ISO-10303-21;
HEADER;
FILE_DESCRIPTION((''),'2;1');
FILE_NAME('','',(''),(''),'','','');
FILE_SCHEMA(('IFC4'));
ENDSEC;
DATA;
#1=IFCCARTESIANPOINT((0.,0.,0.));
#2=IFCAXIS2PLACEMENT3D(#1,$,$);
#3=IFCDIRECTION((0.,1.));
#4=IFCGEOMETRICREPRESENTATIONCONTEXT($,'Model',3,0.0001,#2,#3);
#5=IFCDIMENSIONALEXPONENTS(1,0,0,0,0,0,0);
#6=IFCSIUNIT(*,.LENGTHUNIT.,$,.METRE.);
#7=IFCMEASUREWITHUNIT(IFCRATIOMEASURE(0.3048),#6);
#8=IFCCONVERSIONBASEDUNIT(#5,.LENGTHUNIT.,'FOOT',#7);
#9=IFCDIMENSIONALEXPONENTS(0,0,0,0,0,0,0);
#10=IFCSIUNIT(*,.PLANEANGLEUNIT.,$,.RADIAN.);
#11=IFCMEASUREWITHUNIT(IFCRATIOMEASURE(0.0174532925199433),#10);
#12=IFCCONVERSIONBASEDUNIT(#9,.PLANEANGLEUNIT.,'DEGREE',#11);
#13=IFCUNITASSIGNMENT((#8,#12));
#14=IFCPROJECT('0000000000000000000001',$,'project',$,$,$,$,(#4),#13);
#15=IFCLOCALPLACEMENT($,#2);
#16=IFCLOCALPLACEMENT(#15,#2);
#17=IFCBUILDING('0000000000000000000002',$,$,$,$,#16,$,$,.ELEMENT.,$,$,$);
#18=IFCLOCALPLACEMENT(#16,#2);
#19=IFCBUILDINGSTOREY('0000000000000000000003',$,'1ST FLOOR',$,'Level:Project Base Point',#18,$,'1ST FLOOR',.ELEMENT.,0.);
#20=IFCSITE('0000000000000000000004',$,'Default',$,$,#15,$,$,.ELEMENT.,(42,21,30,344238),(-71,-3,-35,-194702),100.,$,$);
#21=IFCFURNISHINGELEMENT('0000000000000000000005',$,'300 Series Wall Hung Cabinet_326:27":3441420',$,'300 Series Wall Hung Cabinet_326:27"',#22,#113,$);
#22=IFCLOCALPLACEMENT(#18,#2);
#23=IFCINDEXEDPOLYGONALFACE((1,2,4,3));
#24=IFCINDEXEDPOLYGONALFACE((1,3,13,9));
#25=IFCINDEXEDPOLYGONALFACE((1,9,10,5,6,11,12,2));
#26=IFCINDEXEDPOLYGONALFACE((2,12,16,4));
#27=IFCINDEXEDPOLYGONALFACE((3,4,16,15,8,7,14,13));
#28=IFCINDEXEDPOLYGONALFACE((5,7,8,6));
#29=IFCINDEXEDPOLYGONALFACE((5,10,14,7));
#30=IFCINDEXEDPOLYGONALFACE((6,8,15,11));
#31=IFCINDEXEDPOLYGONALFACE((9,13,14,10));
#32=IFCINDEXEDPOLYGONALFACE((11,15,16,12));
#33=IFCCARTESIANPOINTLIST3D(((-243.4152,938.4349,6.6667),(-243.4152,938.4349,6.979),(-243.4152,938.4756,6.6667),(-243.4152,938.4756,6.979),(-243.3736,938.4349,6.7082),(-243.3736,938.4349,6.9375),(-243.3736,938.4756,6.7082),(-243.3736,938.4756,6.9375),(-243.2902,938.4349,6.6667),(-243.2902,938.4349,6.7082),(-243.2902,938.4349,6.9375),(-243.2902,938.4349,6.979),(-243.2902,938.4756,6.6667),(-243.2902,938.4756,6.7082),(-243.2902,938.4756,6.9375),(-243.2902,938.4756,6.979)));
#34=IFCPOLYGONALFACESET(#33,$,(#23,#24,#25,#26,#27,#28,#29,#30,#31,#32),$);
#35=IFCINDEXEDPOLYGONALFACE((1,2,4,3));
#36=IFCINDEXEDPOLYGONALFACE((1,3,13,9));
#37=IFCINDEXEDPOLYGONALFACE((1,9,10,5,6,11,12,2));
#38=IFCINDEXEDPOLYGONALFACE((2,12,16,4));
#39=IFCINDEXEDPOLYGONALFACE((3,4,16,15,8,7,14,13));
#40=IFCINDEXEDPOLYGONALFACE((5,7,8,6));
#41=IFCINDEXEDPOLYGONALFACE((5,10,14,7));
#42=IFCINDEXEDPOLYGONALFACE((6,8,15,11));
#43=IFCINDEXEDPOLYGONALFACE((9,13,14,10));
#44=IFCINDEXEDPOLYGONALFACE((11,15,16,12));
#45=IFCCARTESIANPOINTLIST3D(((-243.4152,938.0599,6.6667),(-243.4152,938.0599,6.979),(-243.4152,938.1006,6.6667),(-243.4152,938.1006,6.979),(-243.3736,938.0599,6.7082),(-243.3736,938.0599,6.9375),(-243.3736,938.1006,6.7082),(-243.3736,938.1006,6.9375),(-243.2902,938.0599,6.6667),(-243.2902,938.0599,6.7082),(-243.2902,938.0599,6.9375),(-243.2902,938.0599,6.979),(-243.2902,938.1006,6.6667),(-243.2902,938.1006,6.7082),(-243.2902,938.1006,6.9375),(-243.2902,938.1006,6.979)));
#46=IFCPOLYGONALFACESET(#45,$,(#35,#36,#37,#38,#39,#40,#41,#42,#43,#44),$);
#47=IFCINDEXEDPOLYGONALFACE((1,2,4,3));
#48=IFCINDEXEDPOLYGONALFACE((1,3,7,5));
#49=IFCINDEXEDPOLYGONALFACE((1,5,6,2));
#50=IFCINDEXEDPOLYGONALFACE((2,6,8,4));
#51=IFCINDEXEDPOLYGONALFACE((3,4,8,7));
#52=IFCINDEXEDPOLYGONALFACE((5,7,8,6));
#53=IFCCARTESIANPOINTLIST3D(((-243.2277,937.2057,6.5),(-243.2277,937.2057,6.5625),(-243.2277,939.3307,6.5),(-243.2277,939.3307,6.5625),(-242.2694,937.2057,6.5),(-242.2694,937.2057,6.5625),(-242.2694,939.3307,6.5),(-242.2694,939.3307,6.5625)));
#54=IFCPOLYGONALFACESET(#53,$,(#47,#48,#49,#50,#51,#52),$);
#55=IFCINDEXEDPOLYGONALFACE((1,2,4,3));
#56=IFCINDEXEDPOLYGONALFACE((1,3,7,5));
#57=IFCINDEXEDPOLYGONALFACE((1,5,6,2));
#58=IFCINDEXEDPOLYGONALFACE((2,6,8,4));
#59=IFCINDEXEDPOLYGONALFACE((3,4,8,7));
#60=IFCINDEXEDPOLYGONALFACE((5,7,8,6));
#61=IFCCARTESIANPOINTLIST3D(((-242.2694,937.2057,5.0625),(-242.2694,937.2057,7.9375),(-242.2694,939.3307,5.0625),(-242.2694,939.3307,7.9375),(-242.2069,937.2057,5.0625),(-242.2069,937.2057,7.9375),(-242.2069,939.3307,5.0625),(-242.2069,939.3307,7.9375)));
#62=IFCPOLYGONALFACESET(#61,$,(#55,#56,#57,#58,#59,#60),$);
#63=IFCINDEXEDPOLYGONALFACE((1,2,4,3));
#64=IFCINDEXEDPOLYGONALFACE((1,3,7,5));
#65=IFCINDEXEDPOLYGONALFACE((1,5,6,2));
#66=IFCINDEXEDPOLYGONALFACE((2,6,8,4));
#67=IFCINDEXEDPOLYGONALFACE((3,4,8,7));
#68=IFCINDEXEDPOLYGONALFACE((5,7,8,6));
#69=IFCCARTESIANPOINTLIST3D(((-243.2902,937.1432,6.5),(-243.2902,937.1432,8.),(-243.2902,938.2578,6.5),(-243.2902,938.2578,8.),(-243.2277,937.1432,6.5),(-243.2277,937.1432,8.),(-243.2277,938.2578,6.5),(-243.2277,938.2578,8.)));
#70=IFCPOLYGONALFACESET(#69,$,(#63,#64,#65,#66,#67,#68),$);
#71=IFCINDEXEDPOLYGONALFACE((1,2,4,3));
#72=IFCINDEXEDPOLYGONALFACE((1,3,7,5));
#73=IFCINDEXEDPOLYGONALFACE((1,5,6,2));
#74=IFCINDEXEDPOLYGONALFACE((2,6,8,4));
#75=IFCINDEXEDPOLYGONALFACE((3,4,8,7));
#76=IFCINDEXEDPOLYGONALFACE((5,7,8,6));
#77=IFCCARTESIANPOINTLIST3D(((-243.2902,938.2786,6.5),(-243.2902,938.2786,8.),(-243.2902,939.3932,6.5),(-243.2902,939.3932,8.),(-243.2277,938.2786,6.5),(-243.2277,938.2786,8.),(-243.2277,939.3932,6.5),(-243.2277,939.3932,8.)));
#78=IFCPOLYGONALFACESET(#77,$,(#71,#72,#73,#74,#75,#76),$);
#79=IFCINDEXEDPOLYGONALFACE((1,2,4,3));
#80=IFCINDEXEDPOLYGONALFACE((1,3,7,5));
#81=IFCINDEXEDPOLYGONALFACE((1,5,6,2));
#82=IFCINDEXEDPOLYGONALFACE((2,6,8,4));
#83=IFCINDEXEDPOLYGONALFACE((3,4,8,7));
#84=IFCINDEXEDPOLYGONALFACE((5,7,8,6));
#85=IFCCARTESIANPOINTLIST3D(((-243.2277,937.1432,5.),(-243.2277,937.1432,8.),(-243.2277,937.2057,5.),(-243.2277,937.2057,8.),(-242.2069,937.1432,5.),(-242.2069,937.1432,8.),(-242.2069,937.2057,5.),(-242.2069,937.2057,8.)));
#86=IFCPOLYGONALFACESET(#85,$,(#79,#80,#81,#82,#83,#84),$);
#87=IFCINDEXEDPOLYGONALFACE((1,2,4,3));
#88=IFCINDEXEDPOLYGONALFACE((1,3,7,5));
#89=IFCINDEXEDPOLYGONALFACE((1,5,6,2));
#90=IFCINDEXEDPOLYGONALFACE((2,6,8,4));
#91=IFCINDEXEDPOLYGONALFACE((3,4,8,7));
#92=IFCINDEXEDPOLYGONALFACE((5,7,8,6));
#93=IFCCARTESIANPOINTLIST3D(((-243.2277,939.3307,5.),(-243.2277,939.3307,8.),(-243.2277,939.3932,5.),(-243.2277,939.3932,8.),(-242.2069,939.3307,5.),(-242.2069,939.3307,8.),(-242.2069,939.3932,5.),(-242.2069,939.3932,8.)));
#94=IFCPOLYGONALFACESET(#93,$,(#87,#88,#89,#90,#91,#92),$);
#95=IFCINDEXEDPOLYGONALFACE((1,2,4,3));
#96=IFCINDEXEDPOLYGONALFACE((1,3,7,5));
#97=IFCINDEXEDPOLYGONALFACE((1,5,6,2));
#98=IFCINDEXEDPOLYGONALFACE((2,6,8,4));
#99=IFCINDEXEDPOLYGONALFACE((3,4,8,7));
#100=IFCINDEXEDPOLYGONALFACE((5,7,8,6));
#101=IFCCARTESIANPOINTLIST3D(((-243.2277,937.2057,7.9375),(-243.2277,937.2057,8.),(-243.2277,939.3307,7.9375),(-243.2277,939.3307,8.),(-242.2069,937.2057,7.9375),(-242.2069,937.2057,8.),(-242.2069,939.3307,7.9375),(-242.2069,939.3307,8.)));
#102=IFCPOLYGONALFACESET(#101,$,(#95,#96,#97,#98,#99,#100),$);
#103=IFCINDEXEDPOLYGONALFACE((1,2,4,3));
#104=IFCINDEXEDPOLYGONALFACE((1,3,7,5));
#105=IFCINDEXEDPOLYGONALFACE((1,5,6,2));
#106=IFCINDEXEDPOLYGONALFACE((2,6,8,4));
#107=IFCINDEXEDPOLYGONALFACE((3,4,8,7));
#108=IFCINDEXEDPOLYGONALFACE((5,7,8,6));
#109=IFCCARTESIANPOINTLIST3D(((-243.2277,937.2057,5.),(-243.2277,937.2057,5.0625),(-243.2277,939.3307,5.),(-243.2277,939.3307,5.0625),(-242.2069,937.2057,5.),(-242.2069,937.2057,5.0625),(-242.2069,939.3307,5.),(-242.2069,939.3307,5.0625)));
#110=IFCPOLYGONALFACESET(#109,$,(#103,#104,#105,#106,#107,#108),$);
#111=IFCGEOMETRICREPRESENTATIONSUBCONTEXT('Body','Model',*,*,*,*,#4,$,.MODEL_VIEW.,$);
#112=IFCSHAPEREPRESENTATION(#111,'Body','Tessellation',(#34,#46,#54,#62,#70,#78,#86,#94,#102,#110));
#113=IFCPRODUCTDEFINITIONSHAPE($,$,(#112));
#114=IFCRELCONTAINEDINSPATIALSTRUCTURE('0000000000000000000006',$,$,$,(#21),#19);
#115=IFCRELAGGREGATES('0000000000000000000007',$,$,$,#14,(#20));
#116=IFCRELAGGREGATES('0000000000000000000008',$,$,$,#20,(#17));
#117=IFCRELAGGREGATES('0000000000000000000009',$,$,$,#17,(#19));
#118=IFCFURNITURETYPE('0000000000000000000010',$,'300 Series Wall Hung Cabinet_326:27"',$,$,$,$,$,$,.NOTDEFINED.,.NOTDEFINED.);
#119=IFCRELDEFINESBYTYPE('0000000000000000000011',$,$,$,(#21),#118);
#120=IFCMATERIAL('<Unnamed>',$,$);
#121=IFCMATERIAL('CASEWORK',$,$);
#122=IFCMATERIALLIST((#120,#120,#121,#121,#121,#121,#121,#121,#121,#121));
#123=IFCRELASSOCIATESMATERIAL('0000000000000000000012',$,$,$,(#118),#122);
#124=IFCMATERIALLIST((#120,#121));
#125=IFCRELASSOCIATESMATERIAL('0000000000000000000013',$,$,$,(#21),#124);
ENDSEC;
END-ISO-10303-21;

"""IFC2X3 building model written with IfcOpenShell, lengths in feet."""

from ifc_helpers import new_model, entity, si_unit, converted_unit, direction, frame, frame_2d, origin, origin_2d_with_axis, place, context, subcontext, project, spatial, polyline, rectangle, outline, extrude, source, transform, mapped, material, material_list, type_object, type_shapes, element, save


model = new_model("IFC2X3")

# Units and contexts
model_context = context("Model", 3, precision=0.0001, world=origin(), true_north=direction((0.0, 1.0)))
body_context = subcontext(model_context, "Body", "Model", "MODEL_VIEW")
ifc_project = project(units=[converted_unit("LENGTHUNIT", "FOOT", entity("IfcRatioMeasure", 0.3048), si_unit("LENGTHUNIT", "METRE"), dimensions=[1, 0, 0, 0, 0, 0, 0]), converted_unit("PLANEANGLEUNIT", "DEGREE", entity("IfcRatioMeasure", 0.0174532925199433), si_unit("PLANEANGLEUNIT", "RADIAN"), dimensions=[0, 0, 0, 0, 0, 0, 0])], contexts=[model_context])

# Site, building, storey
site_placement = place(None, origin())
site = spatial("IfcSite", under=ifc_project, at=site_placement, Name="Default", CompositionType="ELEMENT", RefLatitude=(42, 21, 30, 344238), RefLongitude=(-71, -3, -35, -194702), RefElevation=100.0)
building_placement = place(site_placement, origin())
building = spatial("IfcBuilding", under=site, at=building_placement, CompositionType="ELEMENT")
storey_placement = place(building_placement, origin())
storey = spatial("IfcBuildingStorey", under=building, at=storey_placement, Name="1ST FLOOR", ObjectType="Level:Project Base Point", LongName="1ST FLOOR", CompositionType="ELEMENT", Elevation=0.0)

# Furnishing element
ifc_material_1 = material(Name="CASEWORK")
ifc_material_2 = material(Name="<Unnamed>")
ifc_material_list_1 = material_list([ifc_material_2, ifc_material_1])
ifc_material_list_2 = material_list([ifc_material_2, ifc_material_2, ifc_material_1, ifc_material_1, ifc_material_1, ifc_material_1, ifc_material_1, ifc_material_1, ifc_material_1, ifc_material_1])
furniture_type_1 = type_object("IfcFurnitureType", Name="300 Series Wall Hung Cabinet_326:27\"", material=ifc_material_list_2)
shared_shape_1 = source(origin(), body_context, "Body", "SweptSolid", [
    extrude(outline(polyline([(-0.0521, -0.1146), (-0.0521, -0.1562), (0.0729, -0.1562), (0.0729, 0.1562), (-0.0521, 0.1562), (-0.0521, 0.1146), (0.0313, 0.1146), (0.0313, -0.1146), (-0.0521, -0.1146)])), frame((1.2917, 1.1354, 1.8229), z_axis=(-1.0, 0.0, 0.0), x_axis=(0.0, 1.0, 0.0)), (0.0, 0.0, -1.0), 0.0407),
    extrude(outline(polyline([(-0.0521, -0.1146), (-0.0521, -0.1562), (0.0729, -0.1562), (0.0729, 0.1562), (-0.0521, 0.1562), (-0.0521, 0.1146), (0.0313, 0.1146), (0.0313, -0.1146), (-0.0521, -0.1146)])), frame((0.9167, 1.1354, 1.8229), z_axis=(-1.0, 0.0, 0.0), x_axis=(0.0, 1.0, 0.0)), (0.0, 0.0, -1.0), 0.0407),
    extrude(rectangle(XDim=2.125, YDim=0.9583, at=origin_2d_with_axis()), frame((1.125, 0.5417, 1.5), z_axis=(0.0, 0.0, 1.0), x_axis=(-1.0, 0.0, 0.0)), (0.0, 0.0, 1.0), 0.0625),
    extrude(rectangle(XDim=0.0625, YDim=2.125, at=frame_2d((0.0, 0.0), x_axis=(1.0, 0.0))), frame((1.125, 0.0313, 0.0625), z_axis=(0.0, 0.0, 1.0), x_axis=(0.0, 1.0, 0.0)), (0.0, 0.0, 1.0), 2.875),
    extrude(rectangle(XDim=0.0625, YDim=1.1146, at=frame_2d((0.0, 0.0), x_axis=(1.0, 0.0))), frame((0.5573, 1.0521, 1.5), z_axis=(0.0, 0.0, 1.0), x_axis=(0.0, 1.0, 0.0)), (0.0, 0.0, 1.0), 1.5),
    extrude(rectangle(XDim=0.0625, YDim=1.1146, at=frame_2d((0.0, 0.0), x_axis=(1.0, 0.0))), frame((1.6927, 1.0521, 1.5), z_axis=(0.0, 0.0, 1.0), x_axis=(0.0, 1.0, 0.0)), (0.0, 0.0, 1.0), 1.5),
    extrude(rectangle(XDim=0.0625, YDim=1.0208, at=frame_2d((0.0, 0.0), x_axis=(1.0, 0.0))), frame((0.0313, 0.5104, 0.0)), (0.0, 0.0, 1.0), 3.0),
    extrude(rectangle(XDim=0.0625, YDim=1.0208, at=frame_2d((0.0, 0.0), x_axis=(1.0, 0.0))), frame((2.2188, 0.5104, 0.0)), (0.0, 0.0, 1.0), 3.0),
    extrude(rectangle(XDim=2.125, YDim=1.0208, at=frame_2d((0.0, 0.0), x_axis=(1.0, 0.0))), frame((1.125, 0.5104, 2.9375), z_axis=(0.0, 0.0, 1.0), x_axis=(-1.0, 0.0, 0.0)), (0.0, 0.0, 1.0), 0.0625),
    extrude(rectangle(XDim=2.125, YDim=1.0208, at=origin_2d_with_axis()), frame((1.125, 0.5104, 0.0), z_axis=(0.0, 0.0, 1.0), x_axis=(-1.0, 0.0, 0.0)), (0.0, 0.0, 1.0), 0.0625),
])
type_shapes(furniture_type_1, [shared_shape_1])
furnishing_1_placement = place(storey_placement, frame((-242.2069, 937.1432, 5.0), z_axis=(0.0, 0.0, 1.0), x_axis=(0.0, 1.0, 0.0)))
element("IfcFurnishingElement", 1, at=furnishing_1_placement, inside=storey, type_object=furniture_type_1, material=ifc_material_list_1, Name="300 Series Wall Hung Cabinet_326:27\":3441420", ObjectType="300 Series Wall Hung Cabinet_326:27\"", context=body_context, shape_type="MappedRepresentation", body=[
    mapped(shared_shape_1, transform((0.0, 0.0, 0.0), scale=1.0)),
])

save(model, "model.ifc")
